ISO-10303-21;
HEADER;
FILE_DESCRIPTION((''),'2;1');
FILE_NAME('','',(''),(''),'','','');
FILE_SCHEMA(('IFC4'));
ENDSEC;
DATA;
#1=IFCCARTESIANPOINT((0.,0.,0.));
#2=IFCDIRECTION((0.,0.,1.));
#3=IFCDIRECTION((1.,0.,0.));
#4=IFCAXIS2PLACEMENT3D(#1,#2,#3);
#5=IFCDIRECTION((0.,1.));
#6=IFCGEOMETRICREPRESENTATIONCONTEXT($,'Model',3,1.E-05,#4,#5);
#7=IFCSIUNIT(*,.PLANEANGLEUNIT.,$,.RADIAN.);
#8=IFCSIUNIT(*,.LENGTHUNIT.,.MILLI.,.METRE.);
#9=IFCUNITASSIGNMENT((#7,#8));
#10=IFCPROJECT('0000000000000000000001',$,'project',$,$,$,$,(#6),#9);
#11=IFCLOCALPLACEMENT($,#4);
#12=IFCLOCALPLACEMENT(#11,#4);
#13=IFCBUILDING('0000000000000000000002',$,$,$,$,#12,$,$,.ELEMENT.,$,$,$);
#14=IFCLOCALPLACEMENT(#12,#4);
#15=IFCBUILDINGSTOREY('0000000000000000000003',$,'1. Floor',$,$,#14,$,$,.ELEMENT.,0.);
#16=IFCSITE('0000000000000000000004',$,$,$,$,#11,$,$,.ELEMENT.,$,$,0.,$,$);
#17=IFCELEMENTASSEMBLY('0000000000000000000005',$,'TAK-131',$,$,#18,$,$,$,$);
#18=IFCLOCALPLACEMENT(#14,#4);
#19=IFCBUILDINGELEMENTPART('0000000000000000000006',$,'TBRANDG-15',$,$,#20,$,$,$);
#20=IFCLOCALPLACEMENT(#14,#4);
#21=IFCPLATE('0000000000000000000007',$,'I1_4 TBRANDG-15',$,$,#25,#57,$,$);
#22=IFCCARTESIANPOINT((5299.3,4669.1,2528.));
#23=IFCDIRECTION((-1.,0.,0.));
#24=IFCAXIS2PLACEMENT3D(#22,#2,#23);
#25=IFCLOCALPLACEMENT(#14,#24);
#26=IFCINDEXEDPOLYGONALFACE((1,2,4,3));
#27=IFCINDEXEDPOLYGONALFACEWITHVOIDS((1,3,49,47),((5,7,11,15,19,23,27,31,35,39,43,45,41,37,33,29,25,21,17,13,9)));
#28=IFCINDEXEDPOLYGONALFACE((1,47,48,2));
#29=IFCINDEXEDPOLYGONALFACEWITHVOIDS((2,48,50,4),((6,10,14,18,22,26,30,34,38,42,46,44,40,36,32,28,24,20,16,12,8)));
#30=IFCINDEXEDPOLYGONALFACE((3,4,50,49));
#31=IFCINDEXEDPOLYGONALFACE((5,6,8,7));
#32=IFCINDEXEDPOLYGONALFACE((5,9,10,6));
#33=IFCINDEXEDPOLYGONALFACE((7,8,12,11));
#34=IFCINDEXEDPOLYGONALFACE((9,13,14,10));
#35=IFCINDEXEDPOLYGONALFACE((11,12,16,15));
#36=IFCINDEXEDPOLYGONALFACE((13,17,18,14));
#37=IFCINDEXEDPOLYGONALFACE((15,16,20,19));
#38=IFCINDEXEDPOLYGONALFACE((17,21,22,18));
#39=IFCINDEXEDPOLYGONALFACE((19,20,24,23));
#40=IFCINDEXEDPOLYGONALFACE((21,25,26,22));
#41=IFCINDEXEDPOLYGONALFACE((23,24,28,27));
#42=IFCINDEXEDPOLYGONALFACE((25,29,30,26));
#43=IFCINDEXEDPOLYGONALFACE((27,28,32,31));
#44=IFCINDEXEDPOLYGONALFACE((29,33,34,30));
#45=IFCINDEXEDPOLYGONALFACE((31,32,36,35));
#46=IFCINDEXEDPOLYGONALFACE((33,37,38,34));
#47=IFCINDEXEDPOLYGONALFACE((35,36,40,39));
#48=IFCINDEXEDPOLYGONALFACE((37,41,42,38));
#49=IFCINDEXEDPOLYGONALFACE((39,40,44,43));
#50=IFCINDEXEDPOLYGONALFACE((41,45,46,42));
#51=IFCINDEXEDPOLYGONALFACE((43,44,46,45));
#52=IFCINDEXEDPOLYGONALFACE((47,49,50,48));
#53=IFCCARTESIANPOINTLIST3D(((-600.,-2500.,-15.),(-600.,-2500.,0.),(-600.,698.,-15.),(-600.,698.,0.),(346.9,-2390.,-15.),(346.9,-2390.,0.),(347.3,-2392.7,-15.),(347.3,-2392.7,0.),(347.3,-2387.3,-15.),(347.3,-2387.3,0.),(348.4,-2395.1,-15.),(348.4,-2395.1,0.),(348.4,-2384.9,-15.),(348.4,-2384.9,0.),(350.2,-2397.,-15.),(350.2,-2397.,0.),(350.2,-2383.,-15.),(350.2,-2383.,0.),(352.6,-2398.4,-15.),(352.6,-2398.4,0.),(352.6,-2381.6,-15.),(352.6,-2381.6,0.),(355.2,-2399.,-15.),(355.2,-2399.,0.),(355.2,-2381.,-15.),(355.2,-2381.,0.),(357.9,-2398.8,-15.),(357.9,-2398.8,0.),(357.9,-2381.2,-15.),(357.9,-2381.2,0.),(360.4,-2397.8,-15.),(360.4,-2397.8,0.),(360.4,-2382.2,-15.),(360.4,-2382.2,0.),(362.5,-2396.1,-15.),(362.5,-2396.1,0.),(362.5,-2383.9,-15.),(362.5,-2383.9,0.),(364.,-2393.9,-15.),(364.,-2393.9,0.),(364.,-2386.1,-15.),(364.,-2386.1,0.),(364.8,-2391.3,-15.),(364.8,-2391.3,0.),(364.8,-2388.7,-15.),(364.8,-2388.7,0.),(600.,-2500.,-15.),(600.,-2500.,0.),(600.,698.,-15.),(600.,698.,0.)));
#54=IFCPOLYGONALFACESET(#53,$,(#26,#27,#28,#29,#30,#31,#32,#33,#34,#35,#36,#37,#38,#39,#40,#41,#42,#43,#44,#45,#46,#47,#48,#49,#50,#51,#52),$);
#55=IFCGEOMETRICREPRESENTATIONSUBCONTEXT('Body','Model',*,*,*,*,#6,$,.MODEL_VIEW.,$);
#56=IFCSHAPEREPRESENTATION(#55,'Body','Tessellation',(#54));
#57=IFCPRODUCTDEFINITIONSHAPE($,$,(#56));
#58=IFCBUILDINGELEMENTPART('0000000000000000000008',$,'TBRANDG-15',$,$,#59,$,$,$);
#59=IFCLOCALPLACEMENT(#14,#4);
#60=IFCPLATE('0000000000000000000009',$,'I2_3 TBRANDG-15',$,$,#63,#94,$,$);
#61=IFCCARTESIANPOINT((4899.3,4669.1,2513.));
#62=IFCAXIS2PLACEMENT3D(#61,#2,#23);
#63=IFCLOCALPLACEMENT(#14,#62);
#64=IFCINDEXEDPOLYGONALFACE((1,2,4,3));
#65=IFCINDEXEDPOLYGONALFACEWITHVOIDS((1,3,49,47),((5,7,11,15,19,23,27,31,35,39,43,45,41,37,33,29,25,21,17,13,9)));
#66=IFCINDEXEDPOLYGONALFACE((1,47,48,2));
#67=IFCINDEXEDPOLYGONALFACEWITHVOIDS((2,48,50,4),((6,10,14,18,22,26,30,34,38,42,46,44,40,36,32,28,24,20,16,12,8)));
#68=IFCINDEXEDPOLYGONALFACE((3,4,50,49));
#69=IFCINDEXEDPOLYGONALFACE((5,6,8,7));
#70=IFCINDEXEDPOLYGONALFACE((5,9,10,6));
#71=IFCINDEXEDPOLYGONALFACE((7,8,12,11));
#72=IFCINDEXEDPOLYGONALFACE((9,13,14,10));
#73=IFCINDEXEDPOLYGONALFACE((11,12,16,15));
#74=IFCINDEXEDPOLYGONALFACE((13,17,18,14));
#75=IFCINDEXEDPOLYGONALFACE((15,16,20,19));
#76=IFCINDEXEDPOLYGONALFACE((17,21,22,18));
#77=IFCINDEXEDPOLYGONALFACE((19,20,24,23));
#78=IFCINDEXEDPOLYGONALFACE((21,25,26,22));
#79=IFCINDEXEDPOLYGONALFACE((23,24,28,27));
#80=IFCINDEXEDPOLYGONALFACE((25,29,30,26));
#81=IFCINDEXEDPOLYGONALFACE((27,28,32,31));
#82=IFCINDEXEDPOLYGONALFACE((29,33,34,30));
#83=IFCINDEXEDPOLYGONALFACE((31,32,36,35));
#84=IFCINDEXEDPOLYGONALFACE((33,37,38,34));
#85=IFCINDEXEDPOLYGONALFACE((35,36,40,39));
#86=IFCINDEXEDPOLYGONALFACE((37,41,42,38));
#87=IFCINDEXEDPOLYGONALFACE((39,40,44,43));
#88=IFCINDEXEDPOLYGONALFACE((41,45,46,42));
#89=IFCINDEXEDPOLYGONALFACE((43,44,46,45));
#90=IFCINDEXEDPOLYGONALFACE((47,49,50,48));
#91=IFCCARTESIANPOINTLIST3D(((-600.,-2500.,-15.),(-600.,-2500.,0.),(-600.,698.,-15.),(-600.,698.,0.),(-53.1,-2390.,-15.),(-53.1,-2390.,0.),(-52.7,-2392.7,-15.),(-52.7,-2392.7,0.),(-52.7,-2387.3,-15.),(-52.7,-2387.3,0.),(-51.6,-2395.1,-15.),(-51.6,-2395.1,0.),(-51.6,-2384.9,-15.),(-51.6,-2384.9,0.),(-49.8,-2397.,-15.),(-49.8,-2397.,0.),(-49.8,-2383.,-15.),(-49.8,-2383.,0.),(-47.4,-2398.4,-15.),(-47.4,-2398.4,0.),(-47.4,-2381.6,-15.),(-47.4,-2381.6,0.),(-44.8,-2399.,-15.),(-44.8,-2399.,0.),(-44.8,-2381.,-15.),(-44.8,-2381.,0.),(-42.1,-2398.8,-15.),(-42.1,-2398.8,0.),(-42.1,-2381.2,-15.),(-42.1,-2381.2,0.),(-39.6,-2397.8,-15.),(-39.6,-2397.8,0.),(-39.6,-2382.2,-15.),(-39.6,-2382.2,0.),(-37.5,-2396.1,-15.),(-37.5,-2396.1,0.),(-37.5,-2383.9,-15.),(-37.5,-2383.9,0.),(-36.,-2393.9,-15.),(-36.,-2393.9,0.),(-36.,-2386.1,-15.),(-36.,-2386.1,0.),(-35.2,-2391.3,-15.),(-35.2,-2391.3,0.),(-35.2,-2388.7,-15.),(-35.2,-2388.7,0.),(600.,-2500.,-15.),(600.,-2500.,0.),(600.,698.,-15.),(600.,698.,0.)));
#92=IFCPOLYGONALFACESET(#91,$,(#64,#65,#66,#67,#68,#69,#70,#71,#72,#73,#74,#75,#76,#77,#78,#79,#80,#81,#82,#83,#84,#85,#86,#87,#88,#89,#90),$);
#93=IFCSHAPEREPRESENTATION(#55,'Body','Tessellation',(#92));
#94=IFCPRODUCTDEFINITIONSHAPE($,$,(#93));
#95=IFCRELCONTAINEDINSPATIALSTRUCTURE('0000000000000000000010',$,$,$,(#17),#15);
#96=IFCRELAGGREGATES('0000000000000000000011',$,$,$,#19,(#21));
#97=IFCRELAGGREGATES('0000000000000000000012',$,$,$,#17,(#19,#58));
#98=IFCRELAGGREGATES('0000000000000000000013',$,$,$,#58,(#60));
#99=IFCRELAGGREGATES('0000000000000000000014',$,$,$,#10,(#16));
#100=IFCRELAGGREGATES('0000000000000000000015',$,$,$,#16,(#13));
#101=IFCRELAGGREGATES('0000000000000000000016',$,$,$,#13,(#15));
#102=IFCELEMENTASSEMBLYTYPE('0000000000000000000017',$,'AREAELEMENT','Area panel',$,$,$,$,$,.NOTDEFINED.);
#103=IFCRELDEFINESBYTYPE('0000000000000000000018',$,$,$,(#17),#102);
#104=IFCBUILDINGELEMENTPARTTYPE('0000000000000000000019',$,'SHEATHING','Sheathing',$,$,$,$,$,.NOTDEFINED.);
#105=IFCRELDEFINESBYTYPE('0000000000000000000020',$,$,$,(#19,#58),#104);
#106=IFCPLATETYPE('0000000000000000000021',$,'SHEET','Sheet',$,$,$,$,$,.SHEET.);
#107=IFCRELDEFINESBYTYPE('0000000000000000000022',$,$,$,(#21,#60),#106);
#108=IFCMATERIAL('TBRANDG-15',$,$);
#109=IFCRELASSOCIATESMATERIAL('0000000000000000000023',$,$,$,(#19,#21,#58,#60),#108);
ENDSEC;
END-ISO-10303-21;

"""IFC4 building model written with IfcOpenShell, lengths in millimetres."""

from ifc_helpers import new_model, si_unit, direction, frame, origin_with_axes, origin_2d_with_axis, place, context, subcontext, project, spatial, rectangle, circle, extrude, boolean, material, type_object, element, aggregate, save


model = new_model("IFC4")

# Units and contexts
model_context = context("Model", 3, precision=1e-05, world=origin_with_axes(), true_north=direction((0.0, 1.0)))
body_context = subcontext(model_context, "Body", "Model", "MODEL_VIEW")
ifc_project = project(units=[si_unit("PLANEANGLEUNIT", "RADIAN"), si_unit("LENGTHUNIT", "METRE", prefix="MILLI")], contexts=[model_context])

# Site, building, storey
site_placement = place(None, origin_with_axes())
site = spatial("IfcSite", under=ifc_project, at=site_placement, CompositionType="ELEMENT", RefElevation=0.0)
building_placement = place(site_placement, origin_with_axes())
building = spatial("IfcBuilding", under=site, at=building_placement, CompositionType="ELEMENT")
storey_placement = place(building_placement, origin_with_axes())
storey = spatial("IfcBuildingStorey", under=building, at=storey_placement, Name="1. Floor", CompositionType="ELEMENT", Elevation=0.0)

# Element assembly
element_assembly_type_1 = type_object("IfcElementAssemblyType", Name="AREAELEMENT", Description="Area panel", PredefinedType="NOTDEFINED")
assembly_1_placement = place(storey_placement, origin_with_axes())
assembly_1 = element("IfcElementAssembly", 1, at=assembly_1_placement, inside=storey, type_object=element_assembly_type_1, Name="TAK-131")

# Shared definitions
building_element_part_type_1 = type_object("IfcBuildingElementPartType", Name="SHEATHING", Description="Sheathing", PredefinedType="NOTDEFINED")
plate_type_1 = type_object("IfcPlateType", Name="SHEET", Description="Sheet", PredefinedType="SHEET")

# Building element part, plate
ifc_material_1 = material(Name="TBRANDG-15")
building_element_part_1_placement = place(storey_placement, origin_with_axes())
building_element_part_1 = element("IfcBuildingElementPart", 2, at=building_element_part_1_placement, type_object=building_element_part_type_1, material=ifc_material_1, Name="TBRANDG-15")
plate_1_placement = place(storey_placement, frame((5299.3, 4669.1, 2528.0), z_axis=(0.0, 0.0, 1.0), x_axis=(-1.0, 0.0, 0.0)))
plate_1 = element("IfcPlate", 3, at=plate_1_placement, type_object=plate_type_1, material=ifc_material_1, Name="I1_4 TBRANDG-15", context=body_context, shape_type="CSG", body=[
    boolean("DIFFERENCE", boolean("DIFFERENCE", extrude(rectangle(XDim=15.0, YDim=1200.0, at=origin_2d_with_axis()), frame((0.0, -2500.0, -7.5), z_axis=(0.0, 1.0, 0.0), x_axis=(0.0, 0.0, 1.0)), (0.0, 0.0, 1.0), 3198.0), extrude(circle(Radius=9.0, at=origin_2d_with_axis()), frame((355.9, -2390.0, 10.0), z_axis=(0.0, 0.0, 1.0), x_axis=(-1.0, 0.0, 0.0)), (0.0, 0.0, -1.0), 50.0)), extrude(circle(Radius=9.0, at=origin_2d_with_axis()), frame((355.9, -2390.0, 10.0), z_axis=(0.0, 0.0, 1.0), x_axis=(-1.0, 0.0, 0.0)), (0.0, 0.0, -1.0), 50.0)),
])
aggregate(building_element_part_1, [plate_1])

# Building element part
building_element_part_2_placement = place(storey_placement, origin_with_axes())
building_element_part_2 = element("IfcBuildingElementPart", 4, at=building_element_part_2_placement, type_object=building_element_part_type_1, material=ifc_material_1, Name="TBRANDG-15")
aggregate(assembly_1, [building_element_part_1, building_element_part_2])

# Plate
plate_2_placement = place(storey_placement, frame((4899.3, 4669.1, 2513.0), z_axis=(0.0, 0.0, 1.0), x_axis=(-1.0, 0.0, 0.0)))
plate_2 = element("IfcPlate", 5, at=plate_2_placement, type_object=plate_type_1, material=ifc_material_1, Name="I2_3 TBRANDG-15", context=body_context, shape_type="CSG", body=[
    boolean("DIFFERENCE", boolean("DIFFERENCE", extrude(rectangle(XDim=15.0, YDim=1200.0, at=origin_2d_with_axis()), frame((0.0, -2500.0, -7.5), z_axis=(0.0, 1.0, 0.0), x_axis=(0.0, 0.0, 1.0)), (0.0, 0.0, 1.0), 3198.0), extrude(circle(Radius=9.0, at=origin_2d_with_axis()), frame((-44.1, -2390.0, 25.0), z_axis=(0.0, 0.0, 1.0), x_axis=(-1.0, 0.0, 0.0)), (0.0, 0.0, -1.0), 50.0)), extrude(circle(Radius=9.0, at=origin_2d_with_axis()), frame((-44.1, -2390.0, 25.0), z_axis=(0.0, 0.0, 1.0), x_axis=(-1.0, 0.0, 0.0)), (0.0, 0.0, -1.0), 50.0)),
])
aggregate(building_element_part_2, [plate_2])

save(model, "model.ifc")
